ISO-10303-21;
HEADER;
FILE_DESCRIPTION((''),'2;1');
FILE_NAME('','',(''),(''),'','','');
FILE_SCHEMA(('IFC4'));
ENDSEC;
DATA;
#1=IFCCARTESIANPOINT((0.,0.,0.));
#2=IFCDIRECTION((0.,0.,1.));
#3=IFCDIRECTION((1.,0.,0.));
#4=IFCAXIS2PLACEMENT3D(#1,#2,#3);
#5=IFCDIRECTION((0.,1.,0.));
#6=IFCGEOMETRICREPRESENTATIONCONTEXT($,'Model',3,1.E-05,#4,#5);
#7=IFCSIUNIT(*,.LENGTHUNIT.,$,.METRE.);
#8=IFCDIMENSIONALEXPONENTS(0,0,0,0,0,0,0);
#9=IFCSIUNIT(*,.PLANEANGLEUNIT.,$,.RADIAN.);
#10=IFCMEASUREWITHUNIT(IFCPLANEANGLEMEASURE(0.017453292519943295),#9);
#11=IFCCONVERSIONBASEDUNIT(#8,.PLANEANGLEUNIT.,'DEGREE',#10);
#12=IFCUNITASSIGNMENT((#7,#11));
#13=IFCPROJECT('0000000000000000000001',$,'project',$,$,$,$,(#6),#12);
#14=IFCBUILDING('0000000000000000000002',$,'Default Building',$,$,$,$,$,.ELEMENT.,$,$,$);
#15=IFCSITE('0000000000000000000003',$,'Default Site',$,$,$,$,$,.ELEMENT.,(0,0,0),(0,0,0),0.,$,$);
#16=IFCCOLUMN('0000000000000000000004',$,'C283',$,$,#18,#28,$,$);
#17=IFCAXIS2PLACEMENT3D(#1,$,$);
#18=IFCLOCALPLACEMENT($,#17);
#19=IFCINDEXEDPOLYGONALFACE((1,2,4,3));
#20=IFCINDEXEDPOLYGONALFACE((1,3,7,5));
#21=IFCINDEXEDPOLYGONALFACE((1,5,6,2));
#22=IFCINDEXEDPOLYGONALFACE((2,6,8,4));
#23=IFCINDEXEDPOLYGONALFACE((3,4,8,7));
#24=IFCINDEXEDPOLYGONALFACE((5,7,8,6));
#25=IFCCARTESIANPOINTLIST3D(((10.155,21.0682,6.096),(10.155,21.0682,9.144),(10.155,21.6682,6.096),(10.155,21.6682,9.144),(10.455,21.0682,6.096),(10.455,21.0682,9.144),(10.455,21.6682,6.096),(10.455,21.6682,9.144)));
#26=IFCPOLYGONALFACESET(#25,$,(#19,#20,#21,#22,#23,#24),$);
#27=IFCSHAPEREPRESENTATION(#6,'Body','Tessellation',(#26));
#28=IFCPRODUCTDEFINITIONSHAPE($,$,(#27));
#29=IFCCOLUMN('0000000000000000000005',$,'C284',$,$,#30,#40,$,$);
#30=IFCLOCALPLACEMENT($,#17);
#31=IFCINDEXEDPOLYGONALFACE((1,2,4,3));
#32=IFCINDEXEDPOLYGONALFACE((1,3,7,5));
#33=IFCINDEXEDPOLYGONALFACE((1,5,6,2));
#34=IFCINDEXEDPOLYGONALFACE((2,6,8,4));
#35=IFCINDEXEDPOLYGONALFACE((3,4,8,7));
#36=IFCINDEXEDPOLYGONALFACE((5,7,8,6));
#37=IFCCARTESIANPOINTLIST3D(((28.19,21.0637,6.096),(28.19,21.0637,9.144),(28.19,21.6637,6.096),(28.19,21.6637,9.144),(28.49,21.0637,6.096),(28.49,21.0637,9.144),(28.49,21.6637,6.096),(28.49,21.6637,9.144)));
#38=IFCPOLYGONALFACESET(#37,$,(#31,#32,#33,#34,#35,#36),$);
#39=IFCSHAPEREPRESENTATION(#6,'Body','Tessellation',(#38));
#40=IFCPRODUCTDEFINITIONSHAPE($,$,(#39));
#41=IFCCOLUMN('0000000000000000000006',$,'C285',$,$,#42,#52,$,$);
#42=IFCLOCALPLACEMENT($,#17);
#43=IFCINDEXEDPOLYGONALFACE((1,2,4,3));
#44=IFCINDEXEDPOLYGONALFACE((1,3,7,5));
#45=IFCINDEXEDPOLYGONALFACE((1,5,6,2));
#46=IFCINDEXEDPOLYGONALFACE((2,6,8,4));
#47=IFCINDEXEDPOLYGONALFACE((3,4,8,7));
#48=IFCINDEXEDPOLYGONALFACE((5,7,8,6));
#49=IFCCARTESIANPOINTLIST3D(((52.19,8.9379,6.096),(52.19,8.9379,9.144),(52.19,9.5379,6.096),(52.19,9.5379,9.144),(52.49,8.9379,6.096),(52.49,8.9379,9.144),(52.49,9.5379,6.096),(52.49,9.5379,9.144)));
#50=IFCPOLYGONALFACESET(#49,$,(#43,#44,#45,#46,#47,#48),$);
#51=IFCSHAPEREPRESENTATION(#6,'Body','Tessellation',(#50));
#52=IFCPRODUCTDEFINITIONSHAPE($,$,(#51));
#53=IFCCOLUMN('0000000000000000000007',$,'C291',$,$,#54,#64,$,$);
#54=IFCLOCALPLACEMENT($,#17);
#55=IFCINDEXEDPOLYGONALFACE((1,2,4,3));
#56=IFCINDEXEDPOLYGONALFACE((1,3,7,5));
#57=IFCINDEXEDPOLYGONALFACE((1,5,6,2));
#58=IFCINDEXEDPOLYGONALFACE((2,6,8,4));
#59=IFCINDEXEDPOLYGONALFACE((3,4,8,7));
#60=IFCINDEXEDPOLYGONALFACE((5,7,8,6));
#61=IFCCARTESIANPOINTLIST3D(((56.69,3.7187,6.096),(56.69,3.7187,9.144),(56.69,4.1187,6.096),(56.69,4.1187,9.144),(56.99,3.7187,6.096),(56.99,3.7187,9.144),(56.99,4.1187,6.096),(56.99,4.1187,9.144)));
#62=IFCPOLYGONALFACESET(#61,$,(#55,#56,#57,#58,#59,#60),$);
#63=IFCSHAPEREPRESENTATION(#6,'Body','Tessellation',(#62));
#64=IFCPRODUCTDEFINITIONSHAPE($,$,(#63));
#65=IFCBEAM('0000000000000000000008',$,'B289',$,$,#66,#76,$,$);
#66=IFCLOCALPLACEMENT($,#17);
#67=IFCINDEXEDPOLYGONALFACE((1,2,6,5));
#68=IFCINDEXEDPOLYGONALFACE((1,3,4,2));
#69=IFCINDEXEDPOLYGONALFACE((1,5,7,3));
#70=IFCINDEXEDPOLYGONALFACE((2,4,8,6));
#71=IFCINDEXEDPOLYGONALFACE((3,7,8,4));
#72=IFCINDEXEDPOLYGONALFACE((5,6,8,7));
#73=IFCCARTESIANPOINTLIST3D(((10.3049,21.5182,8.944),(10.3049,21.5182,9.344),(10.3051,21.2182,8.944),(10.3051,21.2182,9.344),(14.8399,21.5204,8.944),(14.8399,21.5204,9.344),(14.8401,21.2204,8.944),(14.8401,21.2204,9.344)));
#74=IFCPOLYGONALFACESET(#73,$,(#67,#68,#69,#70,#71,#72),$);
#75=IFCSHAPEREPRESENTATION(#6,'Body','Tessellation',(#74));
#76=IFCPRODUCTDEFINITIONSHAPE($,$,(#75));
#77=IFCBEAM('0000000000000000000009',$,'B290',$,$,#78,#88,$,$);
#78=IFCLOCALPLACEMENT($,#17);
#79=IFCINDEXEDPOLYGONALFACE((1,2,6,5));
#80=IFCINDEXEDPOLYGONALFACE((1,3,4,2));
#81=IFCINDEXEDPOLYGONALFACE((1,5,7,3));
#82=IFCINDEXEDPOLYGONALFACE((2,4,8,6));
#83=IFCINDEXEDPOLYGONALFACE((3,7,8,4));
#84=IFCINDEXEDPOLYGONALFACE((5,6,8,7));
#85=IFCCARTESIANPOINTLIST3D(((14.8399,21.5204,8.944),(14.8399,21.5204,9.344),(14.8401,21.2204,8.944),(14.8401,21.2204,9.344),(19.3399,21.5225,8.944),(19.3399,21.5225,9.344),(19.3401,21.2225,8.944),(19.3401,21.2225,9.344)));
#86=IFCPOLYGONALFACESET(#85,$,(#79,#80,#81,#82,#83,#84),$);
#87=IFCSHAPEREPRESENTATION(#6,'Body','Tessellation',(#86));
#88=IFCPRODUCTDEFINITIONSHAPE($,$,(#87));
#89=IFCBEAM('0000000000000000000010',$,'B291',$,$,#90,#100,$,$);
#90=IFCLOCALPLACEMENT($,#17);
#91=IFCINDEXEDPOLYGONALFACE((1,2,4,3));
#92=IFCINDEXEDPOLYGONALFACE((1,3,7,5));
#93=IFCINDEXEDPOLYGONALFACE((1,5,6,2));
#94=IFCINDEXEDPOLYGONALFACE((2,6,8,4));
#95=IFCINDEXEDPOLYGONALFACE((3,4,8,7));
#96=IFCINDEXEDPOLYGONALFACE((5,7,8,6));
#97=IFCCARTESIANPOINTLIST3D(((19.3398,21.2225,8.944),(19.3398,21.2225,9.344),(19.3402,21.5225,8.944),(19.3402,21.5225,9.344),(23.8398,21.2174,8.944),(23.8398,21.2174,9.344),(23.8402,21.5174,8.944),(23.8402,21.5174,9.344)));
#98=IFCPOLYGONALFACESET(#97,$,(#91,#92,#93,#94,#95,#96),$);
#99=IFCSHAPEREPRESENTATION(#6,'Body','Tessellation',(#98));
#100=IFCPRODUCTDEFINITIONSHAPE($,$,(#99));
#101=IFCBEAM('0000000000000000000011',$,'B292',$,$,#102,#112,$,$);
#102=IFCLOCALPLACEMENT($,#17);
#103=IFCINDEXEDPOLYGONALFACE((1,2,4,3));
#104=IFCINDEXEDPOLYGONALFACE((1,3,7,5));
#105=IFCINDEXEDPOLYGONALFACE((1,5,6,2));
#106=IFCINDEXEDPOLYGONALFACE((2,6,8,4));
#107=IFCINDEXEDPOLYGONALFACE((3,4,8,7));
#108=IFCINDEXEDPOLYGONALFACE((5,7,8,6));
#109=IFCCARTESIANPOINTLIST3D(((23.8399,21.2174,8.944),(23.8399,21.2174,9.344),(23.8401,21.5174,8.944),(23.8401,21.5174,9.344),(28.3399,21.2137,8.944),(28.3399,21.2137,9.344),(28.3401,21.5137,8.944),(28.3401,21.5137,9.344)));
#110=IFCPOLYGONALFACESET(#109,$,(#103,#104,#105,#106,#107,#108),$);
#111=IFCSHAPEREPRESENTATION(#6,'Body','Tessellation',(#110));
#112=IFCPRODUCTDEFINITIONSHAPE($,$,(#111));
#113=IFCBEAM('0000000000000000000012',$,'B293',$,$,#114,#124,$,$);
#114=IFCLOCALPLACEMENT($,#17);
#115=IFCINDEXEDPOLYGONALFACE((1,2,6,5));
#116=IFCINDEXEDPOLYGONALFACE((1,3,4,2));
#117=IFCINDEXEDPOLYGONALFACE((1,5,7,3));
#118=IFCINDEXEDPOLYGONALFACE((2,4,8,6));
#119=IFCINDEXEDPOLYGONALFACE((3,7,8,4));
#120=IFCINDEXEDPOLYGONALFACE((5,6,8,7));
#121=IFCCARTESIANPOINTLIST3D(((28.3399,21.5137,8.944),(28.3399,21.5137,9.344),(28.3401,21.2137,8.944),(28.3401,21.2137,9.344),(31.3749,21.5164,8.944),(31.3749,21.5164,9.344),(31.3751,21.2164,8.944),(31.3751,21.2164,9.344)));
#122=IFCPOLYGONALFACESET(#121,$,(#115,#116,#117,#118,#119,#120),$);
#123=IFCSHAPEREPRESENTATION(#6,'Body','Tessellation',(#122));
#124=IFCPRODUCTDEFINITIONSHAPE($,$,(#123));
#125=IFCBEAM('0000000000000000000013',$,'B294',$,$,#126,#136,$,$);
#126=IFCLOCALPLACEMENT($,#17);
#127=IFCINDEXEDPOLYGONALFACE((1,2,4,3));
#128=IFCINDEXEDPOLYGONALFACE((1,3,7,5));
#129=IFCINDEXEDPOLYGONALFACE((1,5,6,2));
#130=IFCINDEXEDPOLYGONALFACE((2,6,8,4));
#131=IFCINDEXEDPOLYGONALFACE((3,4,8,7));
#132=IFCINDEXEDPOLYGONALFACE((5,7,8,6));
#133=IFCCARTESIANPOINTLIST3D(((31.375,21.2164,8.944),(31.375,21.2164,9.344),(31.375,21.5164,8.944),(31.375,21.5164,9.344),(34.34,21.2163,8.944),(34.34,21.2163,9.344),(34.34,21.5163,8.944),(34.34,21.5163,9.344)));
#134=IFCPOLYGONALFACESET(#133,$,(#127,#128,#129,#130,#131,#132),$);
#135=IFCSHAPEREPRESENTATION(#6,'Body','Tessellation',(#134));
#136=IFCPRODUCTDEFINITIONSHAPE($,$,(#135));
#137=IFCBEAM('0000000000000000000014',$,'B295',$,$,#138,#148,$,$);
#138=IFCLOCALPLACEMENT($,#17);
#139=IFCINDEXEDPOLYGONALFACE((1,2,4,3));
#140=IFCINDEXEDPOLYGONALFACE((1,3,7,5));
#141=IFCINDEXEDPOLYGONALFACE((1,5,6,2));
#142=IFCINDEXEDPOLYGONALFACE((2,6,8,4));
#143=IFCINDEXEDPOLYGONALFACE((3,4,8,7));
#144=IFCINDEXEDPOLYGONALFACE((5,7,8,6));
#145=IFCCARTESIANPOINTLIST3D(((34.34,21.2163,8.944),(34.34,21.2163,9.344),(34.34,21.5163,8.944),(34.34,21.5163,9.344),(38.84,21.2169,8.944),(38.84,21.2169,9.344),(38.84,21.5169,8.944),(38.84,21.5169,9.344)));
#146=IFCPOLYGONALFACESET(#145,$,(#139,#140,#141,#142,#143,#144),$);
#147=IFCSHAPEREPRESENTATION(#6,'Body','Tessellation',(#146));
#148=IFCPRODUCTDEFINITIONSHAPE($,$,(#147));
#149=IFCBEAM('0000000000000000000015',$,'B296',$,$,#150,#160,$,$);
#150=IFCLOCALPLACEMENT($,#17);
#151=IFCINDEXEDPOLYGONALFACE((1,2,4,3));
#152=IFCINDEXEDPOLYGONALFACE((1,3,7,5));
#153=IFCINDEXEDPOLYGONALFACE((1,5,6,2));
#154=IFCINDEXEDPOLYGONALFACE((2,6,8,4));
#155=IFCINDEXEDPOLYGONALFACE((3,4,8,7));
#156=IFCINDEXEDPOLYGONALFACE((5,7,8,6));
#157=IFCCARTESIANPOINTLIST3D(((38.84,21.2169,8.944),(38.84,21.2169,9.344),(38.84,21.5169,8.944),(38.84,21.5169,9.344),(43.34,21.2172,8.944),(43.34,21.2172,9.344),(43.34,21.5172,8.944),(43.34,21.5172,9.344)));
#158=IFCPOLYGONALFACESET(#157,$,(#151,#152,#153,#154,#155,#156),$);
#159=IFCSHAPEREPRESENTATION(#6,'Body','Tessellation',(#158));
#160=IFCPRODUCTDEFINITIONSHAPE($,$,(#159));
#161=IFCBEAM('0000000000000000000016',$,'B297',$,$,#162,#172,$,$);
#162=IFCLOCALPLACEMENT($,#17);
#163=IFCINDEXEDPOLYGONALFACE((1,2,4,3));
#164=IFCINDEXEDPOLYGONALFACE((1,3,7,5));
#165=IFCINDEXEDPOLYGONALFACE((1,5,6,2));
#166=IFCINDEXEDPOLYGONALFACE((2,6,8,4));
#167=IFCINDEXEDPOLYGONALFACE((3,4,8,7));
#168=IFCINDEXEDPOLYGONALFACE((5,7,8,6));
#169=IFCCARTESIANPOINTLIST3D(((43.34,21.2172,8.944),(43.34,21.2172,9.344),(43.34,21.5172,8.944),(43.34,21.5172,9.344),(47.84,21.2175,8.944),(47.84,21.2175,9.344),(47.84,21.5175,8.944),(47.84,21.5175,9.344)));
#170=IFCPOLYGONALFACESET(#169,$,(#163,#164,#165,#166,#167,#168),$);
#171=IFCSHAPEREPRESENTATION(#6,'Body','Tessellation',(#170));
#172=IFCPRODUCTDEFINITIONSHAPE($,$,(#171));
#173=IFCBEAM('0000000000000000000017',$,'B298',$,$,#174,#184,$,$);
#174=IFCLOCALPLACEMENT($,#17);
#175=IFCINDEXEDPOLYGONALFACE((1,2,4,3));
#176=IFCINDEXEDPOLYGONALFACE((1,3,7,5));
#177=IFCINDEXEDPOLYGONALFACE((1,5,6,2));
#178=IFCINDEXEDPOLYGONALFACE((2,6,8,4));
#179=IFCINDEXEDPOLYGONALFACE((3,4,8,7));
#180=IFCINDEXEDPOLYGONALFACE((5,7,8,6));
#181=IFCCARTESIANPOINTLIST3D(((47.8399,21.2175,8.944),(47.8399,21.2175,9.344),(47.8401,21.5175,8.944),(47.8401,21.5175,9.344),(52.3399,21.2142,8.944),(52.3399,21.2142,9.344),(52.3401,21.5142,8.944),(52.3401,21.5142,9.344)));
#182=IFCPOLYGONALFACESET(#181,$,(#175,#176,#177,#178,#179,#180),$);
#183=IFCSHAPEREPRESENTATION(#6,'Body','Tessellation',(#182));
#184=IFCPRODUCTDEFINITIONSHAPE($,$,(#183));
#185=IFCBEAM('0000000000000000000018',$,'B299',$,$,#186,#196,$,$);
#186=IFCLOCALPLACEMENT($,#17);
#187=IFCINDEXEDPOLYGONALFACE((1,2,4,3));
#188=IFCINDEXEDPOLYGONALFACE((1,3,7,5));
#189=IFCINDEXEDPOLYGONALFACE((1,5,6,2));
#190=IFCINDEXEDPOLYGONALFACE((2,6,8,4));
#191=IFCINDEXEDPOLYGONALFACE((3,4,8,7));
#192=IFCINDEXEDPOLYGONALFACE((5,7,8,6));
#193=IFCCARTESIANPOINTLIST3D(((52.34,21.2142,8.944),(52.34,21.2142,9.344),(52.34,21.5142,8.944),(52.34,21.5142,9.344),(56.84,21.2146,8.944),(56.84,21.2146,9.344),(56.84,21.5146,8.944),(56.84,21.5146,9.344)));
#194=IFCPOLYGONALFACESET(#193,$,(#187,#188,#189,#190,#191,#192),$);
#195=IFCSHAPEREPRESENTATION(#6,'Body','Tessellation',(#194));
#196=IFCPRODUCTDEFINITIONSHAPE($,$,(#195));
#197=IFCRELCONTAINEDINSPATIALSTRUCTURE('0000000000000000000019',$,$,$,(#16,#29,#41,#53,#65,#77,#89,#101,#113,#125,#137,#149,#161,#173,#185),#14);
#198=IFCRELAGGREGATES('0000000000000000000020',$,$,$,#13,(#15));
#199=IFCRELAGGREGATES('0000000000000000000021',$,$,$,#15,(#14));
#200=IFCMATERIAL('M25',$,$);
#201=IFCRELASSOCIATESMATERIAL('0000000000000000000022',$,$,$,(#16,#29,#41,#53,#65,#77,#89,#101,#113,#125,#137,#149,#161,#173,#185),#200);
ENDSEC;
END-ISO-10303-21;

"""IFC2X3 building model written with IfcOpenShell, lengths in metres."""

from ifc_helpers import new_model, entity, si_unit, converted_unit, direction, frame, frame_2d, origin_with_axes, place, context, project, spatial, rectangle, extrude, material, element, save


model = new_model("IFC2X3")

# Units and contexts
model_context = context("Model", 3, precision=1e-05, world=origin_with_axes(), true_north=direction((0.0, 1.0, 0.0)))
ifc_project = project(units=[si_unit("LENGTHUNIT", "METRE"), converted_unit("PLANEANGLEUNIT", "DEGREE", entity("IfcPlaneAngleMeasure", 0.017453292519943295), si_unit("PLANEANGLEUNIT", "RADIAN"), dimensions=[0, 0, 0, 0, 0, 0, 0])], contexts=[model_context])

# Site, building
site = spatial("IfcSite", under=ifc_project, Name="Default Site", CompositionType="ELEMENT", RefLatitude=(0, 0, 0), RefLongitude=(0, 0, 0), RefElevation=0.0)
building = spatial("IfcBuilding", under=site, Name="Default Building", CompositionType="ELEMENT")

# Columns
ifc_material = material(Name="M25")
placement = place(None, origin_with_axes())
element("IfcColumn", 1, at=placement, inside=building, material=ifc_material, Name="C283", context=model_context, shape_type="SweptSolid", body=[
    extrude(rectangle(XDim=0.3, YDim=0.6, at=frame_2d((0.0, 0.0), x_axis=(1.0, 0.0, 0.0))), frame((10.305, 21.3682, 6.096), z_axis=(0.0, 0.0, 1.0), x_axis=(1.0, 0.0, 0.0)), (0.0, 0.0, 1.0), 3.048),
])
element("IfcColumn", 2, at=placement, inside=building, material=ifc_material, Name="C284", context=model_context, shape_type="SweptSolid", body=[
    extrude(rectangle(XDim=0.3, YDim=0.6, at=frame_2d((0.0, 0.0), x_axis=(1.0, 0.0, 0.0))), frame((28.34, 21.3637, 6.096), z_axis=(0.0, 0.0, 1.0), x_axis=(1.0, 0.0, 0.0)), (0.0, 0.0, 1.0), 3.048),
])
element("IfcColumn", 3, at=placement, inside=building, material=ifc_material, Name="C285", context=model_context, shape_type="SweptSolid", body=[
    extrude(rectangle(XDim=0.3, YDim=0.6, at=frame_2d((0.0, 0.0), x_axis=(1.0, 0.0, 0.0))), frame((52.34, 9.2379, 6.096), z_axis=(0.0, 0.0, 1.0), x_axis=(1.0, 0.0, 0.0)), (0.0, 0.0, 1.0), 3.048),
])
element("IfcColumn", 4, at=placement, inside=building, material=ifc_material, Name="C291", context=model_context, shape_type="SweptSolid", body=[
    extrude(rectangle(XDim=0.3, YDim=0.4, at=frame_2d((0.0, 0.0), x_axis=(1.0, 0.0, 0.0))), frame((56.84, 3.9187, 6.096), z_axis=(0.0, 0.0, 1.0), x_axis=(1.0, 0.0, 0.0)), (0.0, 0.0, 1.0), 3.048),
])

# Beams
element("IfcBeam", 5, at=placement, inside=building, material=ifc_material, Name="B289", context=model_context, shape_type="SweptSolid", body=[
    extrude(rectangle(XDim=0.3, YDim=0.4, at=frame_2d((0.0, 0.0), x_axis=(0.0, 1.0, 0.0))), frame((10.305, 21.3682, 9.144), z_axis=(1.0, 0.000476, 0.0), x_axis=(0.0, 0.0, -1.0)), (0.0, 0.0, 1.0), 4.535),
])
element("IfcBeam", 6, at=placement, inside=building, material=ifc_material, Name="B290", context=model_context, shape_type="SweptSolid", body=[
    extrude(rectangle(XDim=0.3, YDim=0.4, at=frame_2d((0.0, 0.0), x_axis=(0.0, 1.0, 0.0))), frame((14.84, 21.3704, 9.144), z_axis=(1.0, 0.000471, 0.0), x_axis=(0.0, 0.0, -1.0)), (0.0, 0.0, 1.0), 4.5),
])
element("IfcBeam", 7, at=placement, inside=building, material=ifc_material, Name="B291", context=model_context, shape_type="SweptSolid", body=[
    extrude(rectangle(XDim=0.3, YDim=0.4, at=frame_2d((0.0, 0.0), x_axis=(0.0, 1.0, 0.0))), frame((19.34, 21.3725, 9.144), z_axis=(0.999999, -0.001141, 0.0), x_axis=(0.0, 0.0, -1.0)), (0.0, 0.0, 1.0), 4.5),
])
element("IfcBeam", 8, at=placement, inside=building, material=ifc_material, Name="B292", context=model_context, shape_type="SweptSolid", body=[
    extrude(rectangle(XDim=0.3, YDim=0.4, at=frame_2d((0.0, 0.0), x_axis=(0.0, 1.0, 0.0))), frame((23.84, 21.3674, 9.144), z_axis=(1.0, -0.000812, 0.0), x_axis=(0.0, 0.0, -1.0)), (0.0, 0.0, 1.0), 4.5),
])
element("IfcBeam", 9, at=placement, inside=building, material=ifc_material, Name="B293", context=model_context, shape_type="SweptSolid", body=[
    extrude(rectangle(XDim=0.3, YDim=0.4, at=frame_2d((0.0, 0.0), x_axis=(0.0, 1.0, 0.0))), frame((28.34, 21.3637, 9.144), z_axis=(1.0, 0.000883, 0.0), x_axis=(0.0, 0.0, -1.0)), (0.0, 0.0, 1.0), 3.035),
])
element("IfcBeam", 10, at=placement, inside=building, material=ifc_material, Name="B294", context=model_context, shape_type="SweptSolid", body=[
    extrude(rectangle(XDim=0.3, YDim=0.4, at=frame_2d((0.0, 0.0), x_axis=(0.0, 1.0, 0.0))), frame((31.375, 21.3664, 9.144), z_axis=(1.0, -0.000016, 0.0), x_axis=(0.0, 0.0, -1.0)), (0.0, 0.0, 1.0), 2.965),
])
element("IfcBeam", 11, at=placement, inside=building, material=ifc_material, Name="B295", context=model_context, shape_type="SweptSolid", body=[
    extrude(rectangle(XDim=0.3, YDim=0.4, at=frame_2d((0.0, 0.0), x_axis=(0.0, 1.0, 0.0))), frame((34.34, 21.3663, 9.144), z_axis=(1.0, 0.000136, 0.0), x_axis=(0.0, 0.0, -1.0)), (0.0, 0.0, 1.0), 4.5),
])
element("IfcBeam", 12, at=placement, inside=building, material=ifc_material, Name="B296", context=model_context, shape_type="SweptSolid", body=[
    extrude(rectangle(XDim=0.3, YDim=0.4, at=frame_2d((0.0, 0.0), x_axis=(0.0, 1.0, 0.0))), frame((38.84, 21.3669, 9.144), z_axis=(1.0, 0.00005, 0.0), x_axis=(0.0, 0.0, -1.0)), (0.0, 0.0, 1.0), 4.5),
])
element("IfcBeam", 13, at=placement, inside=building, material=ifc_material, Name="B297", context=model_context, shape_type="SweptSolid", body=[
    extrude(rectangle(XDim=0.3, YDim=0.4, at=frame_2d((0.0, 0.0), x_axis=(0.0, 1.0, 0.0))), frame((43.34, 21.3672, 9.144), z_axis=(1.0, 0.000075, 0.0), x_axis=(0.0, 0.0, -1.0)), (0.0, 0.0, 1.0), 4.5),
])
element("IfcBeam", 14, at=placement, inside=building, material=ifc_material, Name="B298", context=model_context, shape_type="SweptSolid", body=[
    extrude(rectangle(XDim=0.3, YDim=0.4, at=frame_2d((0.0, 0.0), x_axis=(0.0, 1.0, 0.0))), frame((47.84, 21.3675, 9.144), z_axis=(1.0, -0.000744, 0.0), x_axis=(0.0, 0.0, -1.0)), (0.0, 0.0, 1.0), 4.5),
])
element("IfcBeam", 15, at=placement, inside=building, material=ifc_material, Name="B299", context=model_context, shape_type="SweptSolid", body=[
    extrude(rectangle(XDim=0.3, YDim=0.4, at=frame_2d((0.0, 0.0), x_axis=(0.0, 1.0, 0.0))), frame((52.34, 21.3642, 9.144), z_axis=(1.0, 0.000102, 0.0), x_axis=(0.0, 0.0, -1.0)), (0.0, 0.0, 1.0), 4.5),
])

save(model, "model.ifc")
